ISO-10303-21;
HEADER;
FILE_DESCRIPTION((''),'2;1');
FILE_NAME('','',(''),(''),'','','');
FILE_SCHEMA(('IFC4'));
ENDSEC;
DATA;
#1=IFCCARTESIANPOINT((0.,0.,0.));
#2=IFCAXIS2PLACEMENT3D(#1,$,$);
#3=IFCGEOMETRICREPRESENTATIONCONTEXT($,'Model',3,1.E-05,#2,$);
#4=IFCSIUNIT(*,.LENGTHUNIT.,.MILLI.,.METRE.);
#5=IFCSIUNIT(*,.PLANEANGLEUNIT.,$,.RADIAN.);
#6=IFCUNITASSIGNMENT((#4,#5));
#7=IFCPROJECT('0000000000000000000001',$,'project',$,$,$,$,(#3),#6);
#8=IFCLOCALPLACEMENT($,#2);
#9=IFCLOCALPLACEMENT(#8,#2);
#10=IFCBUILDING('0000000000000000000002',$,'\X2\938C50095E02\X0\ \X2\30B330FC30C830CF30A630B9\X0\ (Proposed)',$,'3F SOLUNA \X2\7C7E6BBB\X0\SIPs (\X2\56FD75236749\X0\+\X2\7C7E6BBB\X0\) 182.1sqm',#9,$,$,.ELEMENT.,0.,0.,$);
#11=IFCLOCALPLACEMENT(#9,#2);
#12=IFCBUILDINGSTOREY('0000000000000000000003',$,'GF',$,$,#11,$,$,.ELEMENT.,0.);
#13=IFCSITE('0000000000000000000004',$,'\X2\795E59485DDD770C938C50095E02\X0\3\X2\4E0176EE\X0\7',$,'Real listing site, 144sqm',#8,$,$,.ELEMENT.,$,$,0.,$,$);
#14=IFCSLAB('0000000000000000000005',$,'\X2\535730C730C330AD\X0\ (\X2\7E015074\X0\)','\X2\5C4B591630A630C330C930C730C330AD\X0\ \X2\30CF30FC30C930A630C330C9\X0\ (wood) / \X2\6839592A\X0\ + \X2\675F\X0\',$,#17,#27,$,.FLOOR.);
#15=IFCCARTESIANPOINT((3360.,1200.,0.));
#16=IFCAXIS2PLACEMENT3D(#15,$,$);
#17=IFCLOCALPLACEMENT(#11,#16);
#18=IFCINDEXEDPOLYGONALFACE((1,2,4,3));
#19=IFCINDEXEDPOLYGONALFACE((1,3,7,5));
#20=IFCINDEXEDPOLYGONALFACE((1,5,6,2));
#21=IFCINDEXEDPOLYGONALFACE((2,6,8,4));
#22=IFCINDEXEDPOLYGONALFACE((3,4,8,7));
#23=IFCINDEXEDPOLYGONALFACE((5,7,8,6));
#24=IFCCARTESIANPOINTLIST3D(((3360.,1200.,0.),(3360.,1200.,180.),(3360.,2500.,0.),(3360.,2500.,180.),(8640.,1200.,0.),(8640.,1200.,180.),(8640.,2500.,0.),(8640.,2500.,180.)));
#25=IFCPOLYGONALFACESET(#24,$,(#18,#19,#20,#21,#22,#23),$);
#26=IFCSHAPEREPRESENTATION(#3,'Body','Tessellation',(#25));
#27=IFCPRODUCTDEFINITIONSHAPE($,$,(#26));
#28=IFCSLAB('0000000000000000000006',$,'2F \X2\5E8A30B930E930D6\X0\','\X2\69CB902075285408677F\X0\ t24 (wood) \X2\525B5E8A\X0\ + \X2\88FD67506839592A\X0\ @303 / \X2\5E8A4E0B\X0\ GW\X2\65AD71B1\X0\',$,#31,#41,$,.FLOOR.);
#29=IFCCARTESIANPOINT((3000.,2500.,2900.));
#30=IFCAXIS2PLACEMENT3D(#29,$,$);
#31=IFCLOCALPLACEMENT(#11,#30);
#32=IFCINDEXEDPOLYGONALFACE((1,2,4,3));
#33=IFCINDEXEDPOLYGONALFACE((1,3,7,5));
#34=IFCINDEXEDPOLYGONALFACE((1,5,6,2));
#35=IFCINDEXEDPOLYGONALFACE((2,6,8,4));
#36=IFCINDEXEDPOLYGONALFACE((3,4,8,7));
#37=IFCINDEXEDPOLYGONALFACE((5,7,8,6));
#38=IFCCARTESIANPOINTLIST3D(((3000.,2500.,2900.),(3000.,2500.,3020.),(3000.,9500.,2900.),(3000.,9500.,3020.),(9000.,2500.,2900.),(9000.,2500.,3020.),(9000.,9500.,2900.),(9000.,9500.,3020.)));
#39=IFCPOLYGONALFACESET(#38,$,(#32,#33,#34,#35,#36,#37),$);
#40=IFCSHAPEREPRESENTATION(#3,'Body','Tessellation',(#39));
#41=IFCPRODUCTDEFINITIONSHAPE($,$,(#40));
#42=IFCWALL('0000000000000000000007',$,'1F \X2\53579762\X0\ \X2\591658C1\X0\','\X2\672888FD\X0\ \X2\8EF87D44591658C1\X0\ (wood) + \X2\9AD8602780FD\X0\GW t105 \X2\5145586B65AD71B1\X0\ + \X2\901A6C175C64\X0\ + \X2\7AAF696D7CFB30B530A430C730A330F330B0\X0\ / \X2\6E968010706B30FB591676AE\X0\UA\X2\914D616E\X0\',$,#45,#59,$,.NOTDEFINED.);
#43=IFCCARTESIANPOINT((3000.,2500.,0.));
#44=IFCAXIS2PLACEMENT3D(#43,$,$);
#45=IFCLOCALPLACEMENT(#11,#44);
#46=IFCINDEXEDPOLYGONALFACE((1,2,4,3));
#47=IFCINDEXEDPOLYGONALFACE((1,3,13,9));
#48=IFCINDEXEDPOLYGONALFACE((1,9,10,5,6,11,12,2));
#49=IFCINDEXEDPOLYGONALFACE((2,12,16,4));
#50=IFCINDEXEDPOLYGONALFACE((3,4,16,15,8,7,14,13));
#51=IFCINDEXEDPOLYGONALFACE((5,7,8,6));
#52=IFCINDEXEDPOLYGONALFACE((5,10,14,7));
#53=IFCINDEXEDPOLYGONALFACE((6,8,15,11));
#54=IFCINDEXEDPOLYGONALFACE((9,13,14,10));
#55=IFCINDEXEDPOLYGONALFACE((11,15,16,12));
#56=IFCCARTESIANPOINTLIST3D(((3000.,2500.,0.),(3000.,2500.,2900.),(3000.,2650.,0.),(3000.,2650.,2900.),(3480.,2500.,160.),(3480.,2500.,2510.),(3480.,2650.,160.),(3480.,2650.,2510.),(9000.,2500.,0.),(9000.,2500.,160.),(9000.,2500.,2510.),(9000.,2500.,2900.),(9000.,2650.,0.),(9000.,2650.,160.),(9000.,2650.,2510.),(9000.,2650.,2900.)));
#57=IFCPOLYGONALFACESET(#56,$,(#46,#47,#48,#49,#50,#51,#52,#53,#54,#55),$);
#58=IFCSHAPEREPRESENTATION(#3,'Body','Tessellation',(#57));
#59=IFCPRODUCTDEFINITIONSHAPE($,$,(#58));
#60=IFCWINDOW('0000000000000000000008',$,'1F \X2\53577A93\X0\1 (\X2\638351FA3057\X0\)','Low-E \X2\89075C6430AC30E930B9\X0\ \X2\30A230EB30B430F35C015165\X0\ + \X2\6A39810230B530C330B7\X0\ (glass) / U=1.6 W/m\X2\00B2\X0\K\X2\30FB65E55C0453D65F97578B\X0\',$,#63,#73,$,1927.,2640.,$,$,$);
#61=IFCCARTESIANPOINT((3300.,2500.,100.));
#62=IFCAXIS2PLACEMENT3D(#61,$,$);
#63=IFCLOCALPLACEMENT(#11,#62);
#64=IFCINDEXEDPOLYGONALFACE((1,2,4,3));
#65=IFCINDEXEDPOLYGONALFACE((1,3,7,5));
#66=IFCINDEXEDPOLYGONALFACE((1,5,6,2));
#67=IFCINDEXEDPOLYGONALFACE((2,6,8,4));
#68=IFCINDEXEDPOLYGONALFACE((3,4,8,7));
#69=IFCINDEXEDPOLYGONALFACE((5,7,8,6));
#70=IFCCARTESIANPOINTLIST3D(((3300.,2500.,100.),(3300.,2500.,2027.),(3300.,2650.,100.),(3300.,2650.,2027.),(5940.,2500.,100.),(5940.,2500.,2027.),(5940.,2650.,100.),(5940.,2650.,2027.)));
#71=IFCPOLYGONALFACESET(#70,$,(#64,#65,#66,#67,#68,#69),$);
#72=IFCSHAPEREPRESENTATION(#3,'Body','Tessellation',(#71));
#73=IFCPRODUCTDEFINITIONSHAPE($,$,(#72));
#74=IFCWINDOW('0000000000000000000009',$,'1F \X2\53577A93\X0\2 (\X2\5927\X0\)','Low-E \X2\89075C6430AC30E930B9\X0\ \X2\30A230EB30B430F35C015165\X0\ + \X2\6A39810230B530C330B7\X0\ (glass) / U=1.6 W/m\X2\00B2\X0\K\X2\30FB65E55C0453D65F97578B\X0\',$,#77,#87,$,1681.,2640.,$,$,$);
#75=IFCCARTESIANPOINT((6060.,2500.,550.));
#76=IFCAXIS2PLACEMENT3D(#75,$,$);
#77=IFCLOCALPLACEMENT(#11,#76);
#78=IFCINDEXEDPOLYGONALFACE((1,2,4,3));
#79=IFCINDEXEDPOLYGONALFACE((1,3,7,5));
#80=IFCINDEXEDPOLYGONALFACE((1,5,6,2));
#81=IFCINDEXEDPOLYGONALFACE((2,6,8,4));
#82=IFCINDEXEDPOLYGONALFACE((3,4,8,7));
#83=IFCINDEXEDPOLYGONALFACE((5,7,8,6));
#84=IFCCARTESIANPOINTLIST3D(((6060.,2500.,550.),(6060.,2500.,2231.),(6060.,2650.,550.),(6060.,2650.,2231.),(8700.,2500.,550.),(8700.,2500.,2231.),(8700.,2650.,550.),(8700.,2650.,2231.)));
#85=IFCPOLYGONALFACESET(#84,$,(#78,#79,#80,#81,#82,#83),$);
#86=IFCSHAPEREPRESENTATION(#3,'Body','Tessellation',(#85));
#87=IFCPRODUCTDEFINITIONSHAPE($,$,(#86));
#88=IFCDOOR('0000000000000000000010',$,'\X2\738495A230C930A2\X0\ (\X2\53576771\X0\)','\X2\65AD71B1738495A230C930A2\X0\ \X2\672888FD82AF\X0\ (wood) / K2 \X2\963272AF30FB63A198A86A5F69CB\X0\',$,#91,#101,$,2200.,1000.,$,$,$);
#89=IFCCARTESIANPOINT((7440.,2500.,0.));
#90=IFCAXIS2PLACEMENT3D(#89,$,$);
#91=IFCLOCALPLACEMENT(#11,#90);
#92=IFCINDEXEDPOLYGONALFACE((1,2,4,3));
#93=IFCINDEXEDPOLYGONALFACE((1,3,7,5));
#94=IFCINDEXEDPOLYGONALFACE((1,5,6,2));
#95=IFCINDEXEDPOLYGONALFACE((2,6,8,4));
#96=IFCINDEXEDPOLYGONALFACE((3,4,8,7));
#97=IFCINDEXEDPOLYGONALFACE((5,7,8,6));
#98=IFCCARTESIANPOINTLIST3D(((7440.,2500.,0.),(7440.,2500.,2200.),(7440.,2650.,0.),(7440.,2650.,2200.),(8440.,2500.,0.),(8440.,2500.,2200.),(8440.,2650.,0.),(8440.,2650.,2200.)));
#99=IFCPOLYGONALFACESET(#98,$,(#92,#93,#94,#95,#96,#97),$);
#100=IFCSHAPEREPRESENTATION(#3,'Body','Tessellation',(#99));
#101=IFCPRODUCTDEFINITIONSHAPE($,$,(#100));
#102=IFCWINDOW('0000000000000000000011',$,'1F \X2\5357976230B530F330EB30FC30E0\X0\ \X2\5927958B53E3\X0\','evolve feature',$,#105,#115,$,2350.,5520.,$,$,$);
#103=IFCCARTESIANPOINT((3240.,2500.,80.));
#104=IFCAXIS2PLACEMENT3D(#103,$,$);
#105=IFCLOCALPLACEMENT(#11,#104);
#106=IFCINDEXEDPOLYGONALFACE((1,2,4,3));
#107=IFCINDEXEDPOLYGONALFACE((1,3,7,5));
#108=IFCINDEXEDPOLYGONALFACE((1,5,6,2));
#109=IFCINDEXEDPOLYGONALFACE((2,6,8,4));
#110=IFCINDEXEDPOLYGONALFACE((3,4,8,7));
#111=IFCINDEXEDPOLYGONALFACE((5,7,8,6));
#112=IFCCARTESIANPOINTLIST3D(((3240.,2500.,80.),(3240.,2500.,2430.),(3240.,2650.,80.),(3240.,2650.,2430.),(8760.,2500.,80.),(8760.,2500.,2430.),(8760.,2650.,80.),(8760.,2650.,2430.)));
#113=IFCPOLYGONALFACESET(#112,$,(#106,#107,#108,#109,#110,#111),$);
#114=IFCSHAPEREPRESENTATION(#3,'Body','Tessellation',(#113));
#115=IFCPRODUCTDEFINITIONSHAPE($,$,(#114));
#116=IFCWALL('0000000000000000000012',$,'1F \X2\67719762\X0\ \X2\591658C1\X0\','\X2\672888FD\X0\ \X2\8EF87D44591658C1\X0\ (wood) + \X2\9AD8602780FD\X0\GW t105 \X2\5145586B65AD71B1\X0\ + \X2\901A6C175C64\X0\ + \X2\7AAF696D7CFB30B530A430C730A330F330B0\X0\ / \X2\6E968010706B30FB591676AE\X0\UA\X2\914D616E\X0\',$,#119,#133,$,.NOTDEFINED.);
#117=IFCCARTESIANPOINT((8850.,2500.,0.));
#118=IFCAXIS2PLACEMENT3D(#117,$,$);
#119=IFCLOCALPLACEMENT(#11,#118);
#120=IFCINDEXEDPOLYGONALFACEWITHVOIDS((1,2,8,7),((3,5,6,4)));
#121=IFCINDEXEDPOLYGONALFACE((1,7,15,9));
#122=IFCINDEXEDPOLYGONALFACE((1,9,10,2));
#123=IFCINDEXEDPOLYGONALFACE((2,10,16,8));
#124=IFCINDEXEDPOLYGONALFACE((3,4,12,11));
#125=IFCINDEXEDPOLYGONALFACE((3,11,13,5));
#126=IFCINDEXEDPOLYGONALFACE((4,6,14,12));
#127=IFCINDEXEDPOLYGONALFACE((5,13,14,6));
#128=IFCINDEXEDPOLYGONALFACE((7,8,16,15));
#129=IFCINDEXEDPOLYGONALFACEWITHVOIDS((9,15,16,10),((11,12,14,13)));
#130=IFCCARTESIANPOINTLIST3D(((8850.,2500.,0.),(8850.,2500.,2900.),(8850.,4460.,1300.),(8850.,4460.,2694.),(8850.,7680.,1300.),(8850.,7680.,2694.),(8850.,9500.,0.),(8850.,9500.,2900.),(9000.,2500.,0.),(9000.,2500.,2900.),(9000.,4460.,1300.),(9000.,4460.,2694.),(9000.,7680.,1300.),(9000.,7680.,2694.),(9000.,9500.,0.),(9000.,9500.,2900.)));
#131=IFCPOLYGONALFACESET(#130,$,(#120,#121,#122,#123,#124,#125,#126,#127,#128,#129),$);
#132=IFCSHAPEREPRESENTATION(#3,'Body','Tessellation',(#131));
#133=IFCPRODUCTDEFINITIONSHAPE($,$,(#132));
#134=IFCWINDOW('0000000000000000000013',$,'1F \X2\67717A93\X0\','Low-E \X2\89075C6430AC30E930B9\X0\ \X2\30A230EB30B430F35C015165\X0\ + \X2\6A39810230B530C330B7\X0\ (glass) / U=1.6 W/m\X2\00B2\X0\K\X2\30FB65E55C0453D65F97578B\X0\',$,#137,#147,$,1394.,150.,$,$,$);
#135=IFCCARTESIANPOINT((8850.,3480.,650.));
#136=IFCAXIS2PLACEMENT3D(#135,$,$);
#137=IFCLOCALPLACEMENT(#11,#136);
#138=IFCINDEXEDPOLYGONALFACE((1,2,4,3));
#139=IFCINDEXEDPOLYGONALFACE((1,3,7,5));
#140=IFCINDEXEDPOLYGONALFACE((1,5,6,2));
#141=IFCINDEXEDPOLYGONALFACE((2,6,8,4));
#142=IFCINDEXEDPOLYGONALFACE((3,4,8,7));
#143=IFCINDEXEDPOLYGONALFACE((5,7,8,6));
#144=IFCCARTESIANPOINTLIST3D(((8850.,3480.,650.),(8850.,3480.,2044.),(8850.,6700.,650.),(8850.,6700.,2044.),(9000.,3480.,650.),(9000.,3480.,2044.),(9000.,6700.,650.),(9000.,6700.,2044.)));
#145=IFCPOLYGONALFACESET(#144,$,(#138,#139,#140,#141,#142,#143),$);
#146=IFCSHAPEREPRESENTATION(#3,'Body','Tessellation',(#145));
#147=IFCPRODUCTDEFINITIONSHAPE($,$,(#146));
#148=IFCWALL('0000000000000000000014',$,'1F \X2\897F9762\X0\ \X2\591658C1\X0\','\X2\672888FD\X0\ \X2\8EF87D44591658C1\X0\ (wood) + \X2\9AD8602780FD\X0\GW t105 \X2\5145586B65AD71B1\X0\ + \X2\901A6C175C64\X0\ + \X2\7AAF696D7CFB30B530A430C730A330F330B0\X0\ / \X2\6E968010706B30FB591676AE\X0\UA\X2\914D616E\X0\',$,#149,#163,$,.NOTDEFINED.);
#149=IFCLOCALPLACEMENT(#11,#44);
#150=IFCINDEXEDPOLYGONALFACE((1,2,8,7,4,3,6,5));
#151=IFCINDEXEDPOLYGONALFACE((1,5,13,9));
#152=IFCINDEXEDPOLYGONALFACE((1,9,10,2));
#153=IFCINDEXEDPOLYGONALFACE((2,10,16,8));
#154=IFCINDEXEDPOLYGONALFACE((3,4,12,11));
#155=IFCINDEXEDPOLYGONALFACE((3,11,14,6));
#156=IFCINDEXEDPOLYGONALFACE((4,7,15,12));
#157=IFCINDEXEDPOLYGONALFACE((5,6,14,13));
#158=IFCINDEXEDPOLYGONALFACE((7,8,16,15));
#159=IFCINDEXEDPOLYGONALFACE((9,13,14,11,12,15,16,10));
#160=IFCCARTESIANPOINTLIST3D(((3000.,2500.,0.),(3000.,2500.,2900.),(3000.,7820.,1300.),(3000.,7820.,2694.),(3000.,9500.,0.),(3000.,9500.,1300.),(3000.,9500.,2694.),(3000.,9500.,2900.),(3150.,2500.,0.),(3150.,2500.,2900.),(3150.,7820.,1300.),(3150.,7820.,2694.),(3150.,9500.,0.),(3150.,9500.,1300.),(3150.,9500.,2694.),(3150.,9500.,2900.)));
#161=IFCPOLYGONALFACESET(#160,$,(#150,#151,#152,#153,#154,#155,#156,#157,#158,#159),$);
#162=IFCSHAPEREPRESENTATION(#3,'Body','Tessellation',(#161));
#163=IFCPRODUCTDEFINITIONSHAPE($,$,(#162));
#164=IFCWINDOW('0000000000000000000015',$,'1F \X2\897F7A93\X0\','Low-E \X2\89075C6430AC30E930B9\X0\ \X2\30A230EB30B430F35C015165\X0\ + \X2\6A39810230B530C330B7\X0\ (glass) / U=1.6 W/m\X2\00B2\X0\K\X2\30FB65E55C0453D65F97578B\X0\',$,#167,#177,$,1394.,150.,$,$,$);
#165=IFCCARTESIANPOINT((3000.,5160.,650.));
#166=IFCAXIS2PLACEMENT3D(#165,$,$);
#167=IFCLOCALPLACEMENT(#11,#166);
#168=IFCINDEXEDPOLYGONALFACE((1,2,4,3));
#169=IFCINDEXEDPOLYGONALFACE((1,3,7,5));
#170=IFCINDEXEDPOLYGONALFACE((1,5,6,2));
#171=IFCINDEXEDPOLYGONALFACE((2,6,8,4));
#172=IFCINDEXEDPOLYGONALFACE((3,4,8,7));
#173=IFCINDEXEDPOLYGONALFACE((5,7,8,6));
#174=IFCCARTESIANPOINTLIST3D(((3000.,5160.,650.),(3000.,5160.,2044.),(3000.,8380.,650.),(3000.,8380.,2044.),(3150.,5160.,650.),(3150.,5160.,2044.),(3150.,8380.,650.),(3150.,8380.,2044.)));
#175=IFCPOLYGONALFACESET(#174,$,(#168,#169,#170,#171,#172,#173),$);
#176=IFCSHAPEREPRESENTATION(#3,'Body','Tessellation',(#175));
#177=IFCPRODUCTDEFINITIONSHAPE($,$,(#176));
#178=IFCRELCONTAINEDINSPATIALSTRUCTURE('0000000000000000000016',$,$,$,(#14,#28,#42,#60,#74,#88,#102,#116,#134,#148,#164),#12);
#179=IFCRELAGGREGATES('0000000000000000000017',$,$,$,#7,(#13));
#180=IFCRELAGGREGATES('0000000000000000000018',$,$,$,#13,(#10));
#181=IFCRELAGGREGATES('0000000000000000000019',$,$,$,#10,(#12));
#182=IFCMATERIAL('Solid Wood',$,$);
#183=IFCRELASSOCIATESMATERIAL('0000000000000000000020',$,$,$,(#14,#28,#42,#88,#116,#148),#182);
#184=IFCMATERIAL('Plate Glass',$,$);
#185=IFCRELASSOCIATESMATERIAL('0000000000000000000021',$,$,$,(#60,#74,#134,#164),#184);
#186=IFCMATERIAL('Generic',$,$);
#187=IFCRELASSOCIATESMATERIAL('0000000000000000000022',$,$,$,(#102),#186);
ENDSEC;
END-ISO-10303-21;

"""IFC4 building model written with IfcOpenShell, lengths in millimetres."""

from ifc_helpers import new_model, si_unit, frame, frame_2d, origin, place, context, project, spatial, rectangle, extrude, material, element, fill, save


model = new_model("IFC4")

# Units and contexts
model_context = context("Model", 3, precision=1e-05, world=origin())
ifc_project = project(units=[si_unit("LENGTHUNIT", "METRE", prefix="MILLI"), si_unit("PLANEANGLEUNIT", "RADIAN")], contexts=[model_context])

# Site, building, storey
site_placement = place(None, origin())
site = spatial("IfcSite", under=ifc_project, at=site_placement, Name="神奈川県鎌倉市3丁目7", ObjectType="Real listing site, 144sqm", CompositionType="ELEMENT", RefElevation=0.0)
building_placement = place(site_placement, origin())
building = spatial("IfcBuilding", under=site, at=building_placement, Name="鎌倉市 コートハウス (Proposed)", ObjectType="3F SOLUNA 籾殻SIPs (国産杉+籾殻) 182.1sqm", CompositionType="ELEMENT", ElevationOfRefHeight=0.0, ElevationOfTerrain=0.0)
storey_placement = place(building_placement, origin())
storey = spatial("IfcBuildingStorey", under=building, at=storey_placement, Name="GF", CompositionType="ELEMENT", Elevation=0.0)

# Slabs
ifc_material_1 = material(Name="Solid Wood")
slab_1_placement = place(storey_placement, frame((3360.0, 1200.0, 0.0)))
element("IfcSlab", 1, at=slab_1_placement, inside=storey, material=ifc_material_1, Name="南デッキ (縁側)", Description="屋外ウッドデッキ ハードウッド (wood) / 根太 + 束", PredefinedType="FLOOR", context=model_context, shape_type="SweptSolid", body=[
    extrude(rectangle(XDim=5280.0, YDim=1300.0, at=frame_2d((2640.0, 650.0))), frame((3360.0, 1200.0, 0.0)), (0.0, 0.0, 1.0), 180.0),
])
slab_2_placement = place(storey_placement, frame((3000.0, 2500.0, 2900.0)))
element("IfcSlab", 2, at=slab_2_placement, inside=storey, material=ifc_material_1, Name="2F 床スラブ", Description="構造用合板 t24 (wood) 剛床 + 製材根太 @303 / 床下 GW断熱", PredefinedType="FLOOR", context=model_context, shape_type="SweptSolid", body=[
    extrude(rectangle(XDim=6000.0, YDim=7000.0, at=frame_2d((3000.0, 3500.0))), frame((3000.0, 2500.0, 2900.0)), (0.0, 0.0, 1.0), 120.0),
])

# Wall, openings, windows, door
wall_1_placement = place(storey_placement, frame((3000.0, 2500.0, 0.0)))
wall_1 = element("IfcWall", 3, at=wall_1_placement, inside=storey, material=ifc_material_1, Name="1F 南面 外壁", Description="木製 軸組外壁 (wood) + 高性能GW t105 充填断熱 + 通気層 + 窯業系サイディング / 準耐火・外皮UA配慮", PredefinedType="NOTDEFINED", context=model_context, shape_type="SweptSolid", body=[
    extrude(rectangle(XDim=6000.0, YDim=150.0, at=frame_2d((3000.0, 75.0))), frame((3000.0, 2500.0, 0.0)), (0.0, 0.0, 1.0), 2900.0),
])
opening_1_placement = place(storey_placement, frame((3300.0, 2500.0, 100.0)))
opening_1 = element("IfcOpeningElement", 4, at=opening_1_placement, cuts=wall_1, PredefinedType="NOTDEFINED", context=model_context, shape_type="SweptSolid", body=[
    extrude(rectangle(XDim=2640.0, YDim=150.0, at=frame_2d((1320.0, 75.0))), frame((3300.0, 2500.0, 100.0)), (0.0, 0.0, 1.0), 1927.0),
])
opening_2_placement = place(storey_placement, frame((6060.0, 2500.0, 550.0)))
opening_2 = element("IfcOpeningElement", 5, at=opening_2_placement, cuts=wall_1, PredefinedType="NOTDEFINED", context=model_context, shape_type="SweptSolid", body=[
    extrude(rectangle(XDim=2640.0, YDim=150.0, at=frame_2d((1320.0, 75.0))), frame((6060.0, 2500.0, 550.0)), (0.0, 0.0, 1.0), 1681.0),
])
opening_3_placement = place(storey_placement, frame((7440.0, 2500.0, 0.0)))
opening_3 = element("IfcOpeningElement", 6, at=opening_3_placement, cuts=wall_1, PredefinedType="NOTDEFINED", context=model_context, shape_type="SweptSolid", body=[
    extrude(rectangle(XDim=1000.0, YDim=150.0, at=frame_2d((500.0, 75.0))), frame((7440.0, 2500.0, 0.0)), (0.0, 0.0, 1.0), 2200.0),
])
opening_4_placement = place(storey_placement, frame((3240.0, 2500.0, 80.0)))
opening_4 = element("IfcOpeningElement", 7, at=opening_4_placement, cuts=wall_1, PredefinedType="NOTDEFINED", context=model_context, shape_type="SweptSolid", body=[
    extrude(rectangle(XDim=5520.0, YDim=150.0, at=frame_2d((2760.0, 75.0))), frame((3240.0, 2500.0, 80.0)), (0.0, 0.0, 1.0), 2350.0),
])
ifc_material_2 = material(Name="Plate Glass")
window_1_placement = place(storey_placement, frame((3300.0, 2500.0, 100.0)))
window_1 = element("IfcWindow", 8, at=window_1_placement, inside=storey, material=ifc_material_2, Name="1F 南窓1 (掃出し)", Description="Low-E 複層ガラス アルゴン封入 + 樹脂サッシ (glass) / U=1.6 W/m²K・日射取得型", OverallHeight=1927.0, OverallWidth=2640.0, context=model_context, shape_type="SweptSolid", body=[
    extrude(rectangle(XDim=2640.0, YDim=150.0, at=frame_2d((1320.0, 75.0))), frame((3300.0, 2500.0, 100.0)), (0.0, 0.0, 1.0), 1927.0),
])
fill(opening_1, window_1)
window_2_placement = place(storey_placement, frame((6060.0, 2500.0, 550.0)))
window_2 = element("IfcWindow", 9, at=window_2_placement, inside=storey, material=ifc_material_2, Name="1F 南窓2 (大)", Description="Low-E 複層ガラス アルゴン封入 + 樹脂サッシ (glass) / U=1.6 W/m²K・日射取得型", OverallHeight=1681.0, OverallWidth=2640.0, context=model_context, shape_type="SweptSolid", body=[
    extrude(rectangle(XDim=2640.0, YDim=150.0, at=frame_2d((1320.0, 75.0))), frame((6060.0, 2500.0, 550.0)), (0.0, 0.0, 1.0), 1681.0),
])
fill(opening_2, window_2)
door_placement = place(storey_placement, frame((7440.0, 2500.0, 0.0)))
door = element("IfcDoor", 10, at=door_placement, inside=storey, material=ifc_material_1, Name="玄関ドア (南東)", Description="断熱玄関ドア 木製芯 (wood) / K2 防犯・採風機構", OverallHeight=2200.0, OverallWidth=1000.0, context=model_context, shape_type="SweptSolid", body=[
    extrude(rectangle(XDim=1000.0, YDim=150.0, at=frame_2d((500.0, 75.0))), frame((7440.0, 2500.0, 0.0)), (0.0, 0.0, 1.0), 2200.0),
])
fill(opening_3, door)
ifc_material_3 = material(Name="Generic")
window_3_placement = place(storey_placement, frame((3240.0, 2500.0, 80.0)))
window_3 = element("IfcWindow", 11, at=window_3_placement, inside=storey, material=ifc_material_3, Name="1F 南面サンルーム 大開口", Description="evolve feature", OverallHeight=2350.0, OverallWidth=5520.0, context=model_context, shape_type="SweptSolid", body=[
    extrude(rectangle(XDim=5520.0, YDim=150.0, at=frame_2d((2760.0, 75.0))), frame((3240.0, 2500.0, 80.0)), (0.0, 0.0, 1.0), 2350.0),
])
fill(opening_4, window_3)

# Walls, openings, windows
wall_2_placement = place(storey_placement, frame((8850.0, 2500.0, 0.0)))
wall_2 = element("IfcWall", 12, at=wall_2_placement, inside=storey, material=ifc_material_1, Name="1F 東面 外壁", Description="木製 軸組外壁 (wood) + 高性能GW t105 充填断熱 + 通気層 + 窯業系サイディング / 準耐火・外皮UA配慮", PredefinedType="NOTDEFINED", context=model_context, shape_type="SweptSolid", body=[
    extrude(rectangle(XDim=150.0, YDim=7000.0, at=frame_2d((75.0, 3500.0))), frame((8850.0, 2500.0, 0.0)), (0.0, 0.0, 1.0), 2900.0),
])
opening_5_placement = place(storey_placement, frame((8850.0, 3480.0, 650.0)))
opening_5 = element("IfcOpeningElement", 13, at=opening_5_placement, cuts=wall_2, PredefinedType="NOTDEFINED", context=model_context, shape_type="SweptSolid", body=[
    extrude(rectangle(XDim=150.0, YDim=3220.0, at=frame_2d((75.0, 1610.0))), frame((8850.0, 3480.0, 650.0)), (0.0, 0.0, 1.0), 1394.0),
])
window_4_placement = place(storey_placement, frame((8850.0, 3480.0, 650.0)))
window_4 = element("IfcWindow", 14, at=window_4_placement, inside=storey, material=ifc_material_2, Name="1F 東窓", Description="Low-E 複層ガラス アルゴン封入 + 樹脂サッシ (glass) / U=1.6 W/m²K・日射取得型", OverallHeight=1394.0, OverallWidth=150.0, context=model_context, shape_type="SweptSolid", body=[
    extrude(rectangle(XDim=150.0, YDim=3220.0, at=frame_2d((75.0, 1610.0))), frame((8850.0, 3480.0, 650.0)), (0.0, 0.0, 1.0), 1394.0),
])
fill(opening_5, window_4)
wall_3_placement = place(storey_placement, frame((3000.0, 2500.0, 0.0)))
wall_3 = element("IfcWall", 15, at=wall_3_placement, inside=storey, material=ifc_material_1, Name="1F 西面 外壁", Description="木製 軸組外壁 (wood) + 高性能GW t105 充填断熱 + 通気層 + 窯業系サイディング / 準耐火・外皮UA配慮", PredefinedType="NOTDEFINED", context=model_context, shape_type="SweptSolid", body=[
    extrude(rectangle(XDim=150.0, YDim=7000.0, at=frame_2d((75.0, 3500.0))), frame((3000.0, 2500.0, 0.0)), (0.0, 0.0, 1.0), 2900.0),
])
opening_6_placement = place(storey_placement, frame((3000.0, 5160.0, 650.0)))
opening_6 = element("IfcOpeningElement", 16, at=opening_6_placement, cuts=wall_3, PredefinedType="NOTDEFINED", context=model_context, shape_type="SweptSolid", body=[
    extrude(rectangle(XDim=150.0, YDim=3220.0, at=frame_2d((75.0, 1610.0))), frame((3000.0, 5160.0, 650.0)), (0.0, 0.0, 1.0), 1394.0),
])
window_5_placement = place(storey_placement, frame((3000.0, 5160.0, 650.0)))
window_5 = element("IfcWindow", 17, at=window_5_placement, inside=storey, material=ifc_material_2, Name="1F 西窓", Description="Low-E 複層ガラス アルゴン封入 + 樹脂サッシ (glass) / U=1.6 W/m²K・日射取得型", OverallHeight=1394.0, OverallWidth=150.0, context=model_context, shape_type="SweptSolid", body=[
    extrude(rectangle(XDim=150.0, YDim=3220.0, at=frame_2d((75.0, 1610.0))), frame((3000.0, 5160.0, 650.0)), (0.0, 0.0, 1.0), 1394.0),
])
fill(opening_6, window_5)

save(model, "model.ifc")
